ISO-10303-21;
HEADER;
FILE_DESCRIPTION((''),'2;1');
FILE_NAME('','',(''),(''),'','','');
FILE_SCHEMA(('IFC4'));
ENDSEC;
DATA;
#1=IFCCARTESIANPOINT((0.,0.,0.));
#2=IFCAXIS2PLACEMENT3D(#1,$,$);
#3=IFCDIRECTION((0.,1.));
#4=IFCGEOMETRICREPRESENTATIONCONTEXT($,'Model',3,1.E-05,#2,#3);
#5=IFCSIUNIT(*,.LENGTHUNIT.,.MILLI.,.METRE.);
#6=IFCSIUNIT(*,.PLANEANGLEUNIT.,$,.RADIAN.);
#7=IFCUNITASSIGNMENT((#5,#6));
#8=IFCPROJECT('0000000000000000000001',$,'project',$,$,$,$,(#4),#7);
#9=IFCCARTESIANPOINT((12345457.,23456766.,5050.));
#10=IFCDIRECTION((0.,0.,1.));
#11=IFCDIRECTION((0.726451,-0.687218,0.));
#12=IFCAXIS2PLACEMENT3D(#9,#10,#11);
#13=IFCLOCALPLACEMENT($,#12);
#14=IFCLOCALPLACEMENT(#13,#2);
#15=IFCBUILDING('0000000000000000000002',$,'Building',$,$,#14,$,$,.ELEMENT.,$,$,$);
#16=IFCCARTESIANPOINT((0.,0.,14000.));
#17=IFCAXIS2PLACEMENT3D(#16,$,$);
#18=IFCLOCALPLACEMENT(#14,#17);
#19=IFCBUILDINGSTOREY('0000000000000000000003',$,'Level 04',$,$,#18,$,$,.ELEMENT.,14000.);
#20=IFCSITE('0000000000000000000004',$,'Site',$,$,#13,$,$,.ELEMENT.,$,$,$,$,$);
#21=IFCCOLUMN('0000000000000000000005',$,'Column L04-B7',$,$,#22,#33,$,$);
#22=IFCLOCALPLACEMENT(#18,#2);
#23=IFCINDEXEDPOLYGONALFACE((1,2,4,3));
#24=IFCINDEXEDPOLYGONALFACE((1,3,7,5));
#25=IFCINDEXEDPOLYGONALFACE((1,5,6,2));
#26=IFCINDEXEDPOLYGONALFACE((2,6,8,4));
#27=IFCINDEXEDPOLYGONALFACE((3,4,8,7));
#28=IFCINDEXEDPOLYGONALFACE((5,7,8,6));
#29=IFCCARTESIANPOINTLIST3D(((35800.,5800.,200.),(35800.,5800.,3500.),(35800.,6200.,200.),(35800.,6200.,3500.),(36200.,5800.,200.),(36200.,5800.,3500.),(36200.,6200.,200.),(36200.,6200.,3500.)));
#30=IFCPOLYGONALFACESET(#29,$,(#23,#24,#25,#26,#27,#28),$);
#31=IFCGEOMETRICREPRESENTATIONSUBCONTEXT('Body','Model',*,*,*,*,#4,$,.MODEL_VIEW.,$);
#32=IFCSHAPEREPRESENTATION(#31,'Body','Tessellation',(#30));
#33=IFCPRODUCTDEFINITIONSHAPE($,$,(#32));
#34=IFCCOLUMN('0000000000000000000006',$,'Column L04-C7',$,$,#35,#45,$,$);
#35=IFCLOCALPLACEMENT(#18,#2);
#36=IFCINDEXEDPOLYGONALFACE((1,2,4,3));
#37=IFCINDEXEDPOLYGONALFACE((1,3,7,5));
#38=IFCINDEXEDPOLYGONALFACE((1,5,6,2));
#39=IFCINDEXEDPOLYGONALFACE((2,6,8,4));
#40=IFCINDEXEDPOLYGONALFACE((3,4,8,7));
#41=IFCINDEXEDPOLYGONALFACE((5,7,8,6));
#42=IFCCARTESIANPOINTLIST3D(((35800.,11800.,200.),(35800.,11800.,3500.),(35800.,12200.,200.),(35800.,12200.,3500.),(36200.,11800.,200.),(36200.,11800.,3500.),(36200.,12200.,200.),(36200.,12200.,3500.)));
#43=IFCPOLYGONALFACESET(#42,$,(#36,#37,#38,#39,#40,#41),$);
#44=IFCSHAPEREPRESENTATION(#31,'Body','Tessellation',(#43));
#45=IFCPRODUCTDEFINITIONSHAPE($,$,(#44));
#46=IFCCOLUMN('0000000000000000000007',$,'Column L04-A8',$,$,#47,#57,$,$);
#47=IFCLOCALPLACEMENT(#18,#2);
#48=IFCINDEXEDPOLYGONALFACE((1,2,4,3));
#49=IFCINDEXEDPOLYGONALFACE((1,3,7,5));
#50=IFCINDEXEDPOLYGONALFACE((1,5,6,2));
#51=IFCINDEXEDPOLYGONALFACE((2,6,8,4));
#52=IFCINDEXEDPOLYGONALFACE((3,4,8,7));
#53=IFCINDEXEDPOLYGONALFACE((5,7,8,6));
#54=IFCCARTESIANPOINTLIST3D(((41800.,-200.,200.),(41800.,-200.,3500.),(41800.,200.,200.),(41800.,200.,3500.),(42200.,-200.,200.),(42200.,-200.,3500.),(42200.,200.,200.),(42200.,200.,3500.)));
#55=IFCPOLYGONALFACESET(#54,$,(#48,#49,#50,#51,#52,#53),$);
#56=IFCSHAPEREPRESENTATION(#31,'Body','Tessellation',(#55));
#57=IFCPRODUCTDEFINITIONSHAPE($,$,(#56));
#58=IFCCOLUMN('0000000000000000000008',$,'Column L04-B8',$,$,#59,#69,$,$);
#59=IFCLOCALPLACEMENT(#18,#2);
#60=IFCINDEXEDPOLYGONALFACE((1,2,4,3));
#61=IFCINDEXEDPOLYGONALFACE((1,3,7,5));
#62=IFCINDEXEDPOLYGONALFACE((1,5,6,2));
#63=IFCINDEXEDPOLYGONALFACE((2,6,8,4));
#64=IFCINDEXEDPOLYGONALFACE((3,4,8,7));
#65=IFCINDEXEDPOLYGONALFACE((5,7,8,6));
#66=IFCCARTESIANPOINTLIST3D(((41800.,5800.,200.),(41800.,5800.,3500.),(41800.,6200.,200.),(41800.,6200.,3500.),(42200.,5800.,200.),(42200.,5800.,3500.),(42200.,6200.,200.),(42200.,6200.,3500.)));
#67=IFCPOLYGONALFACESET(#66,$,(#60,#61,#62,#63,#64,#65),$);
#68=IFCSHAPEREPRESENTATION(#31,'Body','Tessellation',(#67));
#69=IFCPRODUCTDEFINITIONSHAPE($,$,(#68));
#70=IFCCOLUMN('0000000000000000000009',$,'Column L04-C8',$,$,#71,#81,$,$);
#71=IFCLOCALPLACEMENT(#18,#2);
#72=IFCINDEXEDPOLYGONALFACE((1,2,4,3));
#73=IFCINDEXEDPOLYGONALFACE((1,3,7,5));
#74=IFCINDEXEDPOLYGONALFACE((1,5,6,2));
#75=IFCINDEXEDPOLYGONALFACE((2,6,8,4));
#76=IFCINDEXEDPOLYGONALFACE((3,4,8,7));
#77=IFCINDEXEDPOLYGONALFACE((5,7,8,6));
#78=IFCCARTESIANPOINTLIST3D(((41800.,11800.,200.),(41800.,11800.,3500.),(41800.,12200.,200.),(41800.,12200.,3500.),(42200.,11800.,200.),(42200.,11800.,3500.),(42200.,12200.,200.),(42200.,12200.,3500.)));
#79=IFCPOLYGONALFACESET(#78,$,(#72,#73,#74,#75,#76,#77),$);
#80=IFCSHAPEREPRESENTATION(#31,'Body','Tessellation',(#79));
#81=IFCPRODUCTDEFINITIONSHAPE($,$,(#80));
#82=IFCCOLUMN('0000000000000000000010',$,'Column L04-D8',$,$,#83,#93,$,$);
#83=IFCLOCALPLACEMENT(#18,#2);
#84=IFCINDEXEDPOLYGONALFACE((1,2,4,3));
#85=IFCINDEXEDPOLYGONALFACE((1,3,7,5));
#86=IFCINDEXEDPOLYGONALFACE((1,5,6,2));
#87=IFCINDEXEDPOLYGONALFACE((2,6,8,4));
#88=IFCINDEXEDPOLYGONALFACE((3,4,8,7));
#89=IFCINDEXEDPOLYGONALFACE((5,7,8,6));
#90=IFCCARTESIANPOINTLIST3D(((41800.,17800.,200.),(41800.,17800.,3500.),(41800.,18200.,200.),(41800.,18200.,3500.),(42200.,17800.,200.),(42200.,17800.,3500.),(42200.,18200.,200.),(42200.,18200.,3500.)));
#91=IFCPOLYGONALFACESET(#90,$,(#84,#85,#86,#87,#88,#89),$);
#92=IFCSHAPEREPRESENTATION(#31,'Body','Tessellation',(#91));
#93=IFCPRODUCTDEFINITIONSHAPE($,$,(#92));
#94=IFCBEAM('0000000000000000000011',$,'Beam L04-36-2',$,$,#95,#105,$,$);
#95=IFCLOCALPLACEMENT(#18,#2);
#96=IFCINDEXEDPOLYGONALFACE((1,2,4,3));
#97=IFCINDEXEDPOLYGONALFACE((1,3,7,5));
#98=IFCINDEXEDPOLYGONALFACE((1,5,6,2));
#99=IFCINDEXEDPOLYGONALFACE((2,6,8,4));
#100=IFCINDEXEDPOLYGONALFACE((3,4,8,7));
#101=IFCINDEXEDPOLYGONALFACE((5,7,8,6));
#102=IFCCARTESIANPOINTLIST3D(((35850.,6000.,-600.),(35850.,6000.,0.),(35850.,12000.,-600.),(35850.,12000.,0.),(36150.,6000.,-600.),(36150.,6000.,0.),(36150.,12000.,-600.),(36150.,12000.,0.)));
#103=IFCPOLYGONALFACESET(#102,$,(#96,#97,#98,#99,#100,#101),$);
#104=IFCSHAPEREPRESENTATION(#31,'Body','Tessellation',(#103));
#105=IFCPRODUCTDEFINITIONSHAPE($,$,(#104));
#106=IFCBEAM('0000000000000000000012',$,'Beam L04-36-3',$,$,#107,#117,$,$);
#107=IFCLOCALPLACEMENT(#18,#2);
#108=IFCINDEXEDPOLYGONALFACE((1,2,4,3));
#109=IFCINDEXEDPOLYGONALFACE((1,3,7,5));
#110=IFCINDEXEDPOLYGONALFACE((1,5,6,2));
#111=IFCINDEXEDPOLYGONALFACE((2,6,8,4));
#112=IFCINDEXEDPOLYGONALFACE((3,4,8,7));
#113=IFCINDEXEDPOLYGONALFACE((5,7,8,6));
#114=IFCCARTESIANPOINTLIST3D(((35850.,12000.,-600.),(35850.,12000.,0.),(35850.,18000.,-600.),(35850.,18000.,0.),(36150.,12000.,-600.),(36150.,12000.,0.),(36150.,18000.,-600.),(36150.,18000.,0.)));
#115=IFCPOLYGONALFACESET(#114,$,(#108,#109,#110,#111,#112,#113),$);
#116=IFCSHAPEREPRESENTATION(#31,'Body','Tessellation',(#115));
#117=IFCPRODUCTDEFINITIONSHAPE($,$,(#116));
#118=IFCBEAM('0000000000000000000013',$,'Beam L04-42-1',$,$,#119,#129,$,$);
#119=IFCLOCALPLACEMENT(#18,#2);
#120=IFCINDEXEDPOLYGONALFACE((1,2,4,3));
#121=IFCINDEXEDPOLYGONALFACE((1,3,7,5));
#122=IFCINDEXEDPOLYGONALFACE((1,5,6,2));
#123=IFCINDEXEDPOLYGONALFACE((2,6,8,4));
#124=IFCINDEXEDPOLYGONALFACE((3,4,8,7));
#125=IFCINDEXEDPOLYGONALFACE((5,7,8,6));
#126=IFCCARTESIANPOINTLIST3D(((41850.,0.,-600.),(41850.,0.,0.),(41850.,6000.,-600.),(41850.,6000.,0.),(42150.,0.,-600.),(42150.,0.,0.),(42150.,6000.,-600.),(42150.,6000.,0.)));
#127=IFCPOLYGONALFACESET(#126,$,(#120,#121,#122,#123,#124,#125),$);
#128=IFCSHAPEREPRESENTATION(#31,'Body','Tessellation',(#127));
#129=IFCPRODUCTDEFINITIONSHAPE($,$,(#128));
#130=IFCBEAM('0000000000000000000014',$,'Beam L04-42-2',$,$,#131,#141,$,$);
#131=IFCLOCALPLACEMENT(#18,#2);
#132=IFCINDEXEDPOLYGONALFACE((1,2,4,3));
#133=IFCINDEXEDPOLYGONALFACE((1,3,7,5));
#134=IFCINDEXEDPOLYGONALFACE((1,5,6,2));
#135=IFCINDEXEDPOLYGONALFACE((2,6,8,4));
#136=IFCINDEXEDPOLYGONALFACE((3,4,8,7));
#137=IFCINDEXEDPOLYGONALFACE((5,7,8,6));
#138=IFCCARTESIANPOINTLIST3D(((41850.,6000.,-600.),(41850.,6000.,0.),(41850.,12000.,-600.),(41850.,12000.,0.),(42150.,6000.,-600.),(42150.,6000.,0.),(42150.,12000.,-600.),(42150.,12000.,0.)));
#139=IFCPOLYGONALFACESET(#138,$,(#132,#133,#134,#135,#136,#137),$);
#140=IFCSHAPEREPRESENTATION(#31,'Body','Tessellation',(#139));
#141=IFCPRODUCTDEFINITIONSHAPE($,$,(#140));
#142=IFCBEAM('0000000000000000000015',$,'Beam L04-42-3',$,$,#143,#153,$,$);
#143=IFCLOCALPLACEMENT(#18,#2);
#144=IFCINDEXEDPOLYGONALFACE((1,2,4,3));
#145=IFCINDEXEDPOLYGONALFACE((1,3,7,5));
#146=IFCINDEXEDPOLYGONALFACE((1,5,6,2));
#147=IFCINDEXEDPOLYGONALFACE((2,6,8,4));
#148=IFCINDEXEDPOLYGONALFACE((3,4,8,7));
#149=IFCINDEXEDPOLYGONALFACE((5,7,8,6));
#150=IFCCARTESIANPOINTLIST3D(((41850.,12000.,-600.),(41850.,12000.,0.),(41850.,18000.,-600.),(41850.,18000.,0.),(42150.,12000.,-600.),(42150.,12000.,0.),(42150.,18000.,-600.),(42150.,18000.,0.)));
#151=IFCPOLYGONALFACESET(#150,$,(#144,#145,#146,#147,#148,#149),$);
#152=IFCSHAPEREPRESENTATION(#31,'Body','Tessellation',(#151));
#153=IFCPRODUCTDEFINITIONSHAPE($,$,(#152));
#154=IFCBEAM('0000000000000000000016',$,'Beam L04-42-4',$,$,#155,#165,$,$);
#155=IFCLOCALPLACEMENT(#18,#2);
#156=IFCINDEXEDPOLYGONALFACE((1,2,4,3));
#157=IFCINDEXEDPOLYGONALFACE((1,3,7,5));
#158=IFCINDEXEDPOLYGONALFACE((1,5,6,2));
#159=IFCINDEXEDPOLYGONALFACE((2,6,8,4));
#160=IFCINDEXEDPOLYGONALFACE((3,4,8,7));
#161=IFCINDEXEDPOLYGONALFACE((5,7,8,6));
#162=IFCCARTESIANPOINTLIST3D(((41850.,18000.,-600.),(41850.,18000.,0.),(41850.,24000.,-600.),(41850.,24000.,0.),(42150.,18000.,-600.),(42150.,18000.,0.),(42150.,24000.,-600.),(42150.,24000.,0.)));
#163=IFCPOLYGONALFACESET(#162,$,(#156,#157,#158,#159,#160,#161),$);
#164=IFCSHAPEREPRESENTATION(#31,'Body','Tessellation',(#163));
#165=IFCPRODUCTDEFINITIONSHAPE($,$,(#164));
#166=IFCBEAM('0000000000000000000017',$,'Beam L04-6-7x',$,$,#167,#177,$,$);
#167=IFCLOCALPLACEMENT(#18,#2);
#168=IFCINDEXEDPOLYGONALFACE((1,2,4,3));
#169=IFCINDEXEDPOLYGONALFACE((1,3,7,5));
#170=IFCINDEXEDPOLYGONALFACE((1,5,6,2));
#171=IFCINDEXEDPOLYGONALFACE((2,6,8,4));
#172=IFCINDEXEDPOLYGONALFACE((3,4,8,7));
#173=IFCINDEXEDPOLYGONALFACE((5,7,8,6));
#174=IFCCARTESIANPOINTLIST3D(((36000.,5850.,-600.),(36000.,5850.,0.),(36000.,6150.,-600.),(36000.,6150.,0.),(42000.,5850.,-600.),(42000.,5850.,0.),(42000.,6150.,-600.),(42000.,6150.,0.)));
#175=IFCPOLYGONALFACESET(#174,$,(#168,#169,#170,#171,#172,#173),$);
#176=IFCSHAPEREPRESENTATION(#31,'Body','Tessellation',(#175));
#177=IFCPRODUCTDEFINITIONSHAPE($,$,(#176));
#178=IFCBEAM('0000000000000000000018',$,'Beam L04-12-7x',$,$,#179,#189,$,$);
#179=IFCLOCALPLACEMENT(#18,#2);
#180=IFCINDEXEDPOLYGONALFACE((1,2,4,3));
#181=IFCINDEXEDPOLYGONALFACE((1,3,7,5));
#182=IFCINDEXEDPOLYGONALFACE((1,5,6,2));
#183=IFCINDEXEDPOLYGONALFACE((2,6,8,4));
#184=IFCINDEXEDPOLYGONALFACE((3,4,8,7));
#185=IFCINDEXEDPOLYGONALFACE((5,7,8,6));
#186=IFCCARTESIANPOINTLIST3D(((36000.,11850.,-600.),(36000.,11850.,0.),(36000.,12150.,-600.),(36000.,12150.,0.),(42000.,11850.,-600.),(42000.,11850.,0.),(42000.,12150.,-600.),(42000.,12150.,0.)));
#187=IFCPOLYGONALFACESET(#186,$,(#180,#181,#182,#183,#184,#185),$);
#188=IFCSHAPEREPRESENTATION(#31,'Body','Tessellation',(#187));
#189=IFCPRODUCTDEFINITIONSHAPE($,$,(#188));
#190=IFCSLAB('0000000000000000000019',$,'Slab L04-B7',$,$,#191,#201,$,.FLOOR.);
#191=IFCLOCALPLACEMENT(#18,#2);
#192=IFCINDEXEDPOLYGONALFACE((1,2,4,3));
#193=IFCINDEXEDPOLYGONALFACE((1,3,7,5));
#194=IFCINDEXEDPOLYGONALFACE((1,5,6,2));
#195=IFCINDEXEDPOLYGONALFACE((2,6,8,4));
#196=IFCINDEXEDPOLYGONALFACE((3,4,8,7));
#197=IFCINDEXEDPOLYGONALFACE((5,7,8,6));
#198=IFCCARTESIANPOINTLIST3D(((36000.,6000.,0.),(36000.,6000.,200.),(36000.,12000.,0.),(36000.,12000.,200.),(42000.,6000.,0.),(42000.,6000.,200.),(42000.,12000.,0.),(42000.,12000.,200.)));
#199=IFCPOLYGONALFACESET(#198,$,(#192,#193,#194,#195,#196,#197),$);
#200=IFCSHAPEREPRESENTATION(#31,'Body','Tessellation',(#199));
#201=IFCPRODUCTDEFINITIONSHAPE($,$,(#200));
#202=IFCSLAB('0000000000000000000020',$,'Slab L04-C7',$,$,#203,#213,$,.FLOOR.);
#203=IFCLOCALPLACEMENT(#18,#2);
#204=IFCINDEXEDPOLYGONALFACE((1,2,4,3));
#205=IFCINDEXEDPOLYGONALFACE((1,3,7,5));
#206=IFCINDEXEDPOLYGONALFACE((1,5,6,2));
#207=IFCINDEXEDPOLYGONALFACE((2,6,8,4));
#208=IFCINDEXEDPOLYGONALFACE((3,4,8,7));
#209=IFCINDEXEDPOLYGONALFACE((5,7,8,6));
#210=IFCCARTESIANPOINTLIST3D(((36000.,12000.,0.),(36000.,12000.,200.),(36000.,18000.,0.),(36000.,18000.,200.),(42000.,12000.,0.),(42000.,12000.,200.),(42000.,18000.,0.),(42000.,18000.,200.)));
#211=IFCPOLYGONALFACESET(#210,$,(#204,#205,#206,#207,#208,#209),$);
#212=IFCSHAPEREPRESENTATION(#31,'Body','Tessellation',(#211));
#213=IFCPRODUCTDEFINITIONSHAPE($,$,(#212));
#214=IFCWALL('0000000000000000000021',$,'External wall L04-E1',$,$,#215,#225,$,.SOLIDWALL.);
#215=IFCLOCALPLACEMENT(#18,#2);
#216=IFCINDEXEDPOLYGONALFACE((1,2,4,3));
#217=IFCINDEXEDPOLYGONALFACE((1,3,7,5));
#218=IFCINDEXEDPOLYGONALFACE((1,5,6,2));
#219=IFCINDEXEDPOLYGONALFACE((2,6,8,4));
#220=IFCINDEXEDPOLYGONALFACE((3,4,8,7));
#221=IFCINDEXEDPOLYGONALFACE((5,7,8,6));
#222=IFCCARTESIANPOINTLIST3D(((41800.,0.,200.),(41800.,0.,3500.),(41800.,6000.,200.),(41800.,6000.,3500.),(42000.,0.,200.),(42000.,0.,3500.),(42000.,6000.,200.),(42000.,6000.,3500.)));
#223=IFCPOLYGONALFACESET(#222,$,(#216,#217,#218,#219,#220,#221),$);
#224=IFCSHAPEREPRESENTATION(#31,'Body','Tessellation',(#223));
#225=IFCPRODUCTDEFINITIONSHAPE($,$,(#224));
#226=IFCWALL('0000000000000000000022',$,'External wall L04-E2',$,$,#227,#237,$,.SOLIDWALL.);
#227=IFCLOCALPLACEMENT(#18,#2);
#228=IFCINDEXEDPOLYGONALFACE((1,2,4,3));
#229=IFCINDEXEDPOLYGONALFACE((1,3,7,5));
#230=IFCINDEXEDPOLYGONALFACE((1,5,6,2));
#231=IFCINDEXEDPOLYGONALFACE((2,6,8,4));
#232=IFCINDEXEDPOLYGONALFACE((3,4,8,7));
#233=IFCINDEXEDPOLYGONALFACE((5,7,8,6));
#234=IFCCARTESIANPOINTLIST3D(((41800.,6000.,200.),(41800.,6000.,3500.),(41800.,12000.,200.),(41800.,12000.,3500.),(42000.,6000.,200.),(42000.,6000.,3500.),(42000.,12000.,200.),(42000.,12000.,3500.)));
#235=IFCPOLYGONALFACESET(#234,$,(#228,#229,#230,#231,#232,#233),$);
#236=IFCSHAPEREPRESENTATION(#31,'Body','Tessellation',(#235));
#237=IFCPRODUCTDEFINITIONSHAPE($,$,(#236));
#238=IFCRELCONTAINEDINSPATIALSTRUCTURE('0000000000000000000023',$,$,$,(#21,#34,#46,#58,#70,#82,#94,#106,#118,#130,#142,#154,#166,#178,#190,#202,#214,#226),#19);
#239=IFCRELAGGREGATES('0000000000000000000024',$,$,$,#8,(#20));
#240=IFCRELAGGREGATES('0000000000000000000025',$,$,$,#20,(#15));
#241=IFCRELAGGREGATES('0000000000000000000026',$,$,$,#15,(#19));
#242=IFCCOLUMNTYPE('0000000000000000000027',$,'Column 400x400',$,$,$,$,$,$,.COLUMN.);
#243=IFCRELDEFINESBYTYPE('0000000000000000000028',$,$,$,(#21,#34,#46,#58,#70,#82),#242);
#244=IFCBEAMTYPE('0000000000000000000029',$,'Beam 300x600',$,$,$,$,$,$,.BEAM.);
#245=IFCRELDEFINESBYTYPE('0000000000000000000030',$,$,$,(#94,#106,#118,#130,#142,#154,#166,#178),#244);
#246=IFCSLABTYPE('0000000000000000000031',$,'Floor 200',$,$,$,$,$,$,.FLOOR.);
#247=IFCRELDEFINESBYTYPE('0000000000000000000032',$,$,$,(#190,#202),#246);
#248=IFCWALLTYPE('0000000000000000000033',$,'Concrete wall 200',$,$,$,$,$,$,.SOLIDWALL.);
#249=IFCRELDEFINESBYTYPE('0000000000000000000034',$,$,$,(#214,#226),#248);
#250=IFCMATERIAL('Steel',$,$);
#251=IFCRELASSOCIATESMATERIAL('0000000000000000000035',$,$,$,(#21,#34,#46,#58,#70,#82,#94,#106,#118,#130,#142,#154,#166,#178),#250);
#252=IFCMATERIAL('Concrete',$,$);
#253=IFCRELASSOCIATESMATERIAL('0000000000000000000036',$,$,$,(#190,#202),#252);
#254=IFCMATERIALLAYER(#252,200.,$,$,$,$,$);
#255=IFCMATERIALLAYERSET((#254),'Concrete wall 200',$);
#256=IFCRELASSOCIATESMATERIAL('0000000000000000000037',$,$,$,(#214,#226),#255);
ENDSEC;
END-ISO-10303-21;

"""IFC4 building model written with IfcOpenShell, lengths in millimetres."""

from ifc_helpers import new_model, si_unit, direction, frame, origin, place, context, subcontext, project, spatial, rectangle, extrude, material, layer, layer_set, layer_usage, type_object, element, save


model = new_model("IFC4")

# Units and contexts
model_context = context("Model", 3, precision=1e-05, world=origin(), true_north=direction((0.0, 1.0)))
body_context = subcontext(model_context, "Body", "Model", "MODEL_VIEW")
ifc_project = project(units=[si_unit("LENGTHUNIT", "METRE", prefix="MILLI"), si_unit("PLANEANGLEUNIT", "RADIAN")], contexts=[model_context])

# Site, building, storey
site_placement = place(None, frame((12345457.0, 23456766.0, 5050.0), z_axis=(0.0, 0.0, 1.0), x_axis=(0.726451, -0.687218, 0.0)))
site = spatial("IfcSite", under=ifc_project, at=site_placement, Name="Site", CompositionType="ELEMENT")
building_placement = place(site_placement, origin())
building = spatial("IfcBuilding", under=site, at=building_placement, Name="Building", CompositionType="ELEMENT")
storey_placement = place(building_placement, frame((0.0, 0.0, 14000.0)))
storey = spatial("IfcBuildingStorey", under=building, at=storey_placement, Name="Level 04", CompositionType="ELEMENT", Elevation=14000.0)

# Columns
ifc_material_1 = material(Name="Steel")
column_type = type_object("IfcColumnType", Name="Column 400x400", PredefinedType="COLUMN")
for number, where, name in (
    (1, (35800.0, 5800.0, 200.0), "Column L04-B7"),
    (2, (35800.0, 11800.0, 200.0), "Column L04-C7"),
    (3, (41800.0, -200.0, 200.0), "Column L04-A8"),
    (4, (41800.0, 5800.0, 200.0), "Column L04-B8"),
    (5, (41800.0, 11800.0, 200.0), "Column L04-C8"),
    (6, (41800.0, 17800.0, 200.0), "Column L04-D8"),
):
    element("IfcColumn", number, at=place(storey_placement, frame(where)), inside=storey, type_object=column_type, material=ifc_material_1, Name=name, context=body_context, shape_type="SweptSolid", body=[
        extrude(rectangle(XDim=400.0, YDim=400.0), frame((200.0, 200.0, 0.0)), (0.0, 0.0, 1.0), 3300.0),
    ])

# Beams
beam_type = type_object("IfcBeamType", Name="Beam 300x600", PredefinedType="BEAM")
for number, where, name in (
    (7, (35850.0, 6000.0, -600.0), "Beam L04-36-2"),
    (8, (35850.0, 12000.0, -600.0), "Beam L04-36-3"),
    (9, (41850.0, 0.0, -600.0), "Beam L04-42-1"),
    (10, (41850.0, 6000.0, -600.0), "Beam L04-42-2"),
    (11, (41850.0, 12000.0, -600.0), "Beam L04-42-3"),
    (12, (41850.0, 18000.0, -600.0), "Beam L04-42-4"),
):
    element("IfcBeam", number, at=place(storey_placement, frame(where)), inside=storey, type_object=beam_type, material=ifc_material_1, Name=name, context=body_context, shape_type="SweptSolid", body=[
        extrude(rectangle(XDim=300.0, YDim=6000.0), frame((150.0, 3000.0, 0.0)), (0.0, 0.0, 1.0), 600.0),
    ])
for number, where, name in (
    (13, (36000.0, 5850.0, -600.0), "Beam L04-6-7x"),
    (14, (36000.0, 11850.0, -600.0), "Beam L04-12-7x"),
):
    element("IfcBeam", number, at=place(storey_placement, frame(where)), inside=storey, type_object=beam_type, material=ifc_material_1, Name=name, context=body_context, shape_type="SweptSolid", body=[
        extrude(rectangle(XDim=6000.0, YDim=300.0), frame((3000.0, 150.0, 0.0)), (0.0, 0.0, 1.0), 600.0),
    ])

# Slabs
ifc_material_2 = material(Name="Concrete")
slab_type = type_object("IfcSlabType", Name="Floor 200", PredefinedType="FLOOR")
for number, where, name in (
    (15, (36000.0, 6000.0, 0.0), "Slab L04-B7"),
    (16, (36000.0, 12000.0, 0.0), "Slab L04-C7"),
):
    element("IfcSlab", number, at=place(storey_placement, frame(where)), inside=storey, type_object=slab_type, material=ifc_material_2, Name=name, PredefinedType="FLOOR", context=body_context, shape_type="SweptSolid", body=[
        extrude(rectangle(XDim=6000.0, YDim=6000.0), frame((3000.0, 3000.0, 0.0)), (0.0, 0.0, 1.0), 200.0),
    ])

# Walls
ifc_layer_1 = layer(ifc_material_2, 200.0)
ifc_layer_set_1 = layer_set([ifc_layer_1], Name="Concrete wall 200")
ifc_layer_usage_1 = layer_usage(ifc_layer_set_1, "AXIS2", "POSITIVE", 0.0)
wall_type_1 = type_object("IfcWallType", Name="Concrete wall 200", PredefinedType="SOLIDWALL")
for number, where, name in (
    (17, (41800.0, 0.0, 200.0), "External wall L04-E1"),
    (18, (41800.0, 6000.0, 200.0), "External wall L04-E2"),
):
    element("IfcWall", number, at=place(storey_placement, frame(where)), inside=storey, type_object=wall_type_1, material=ifc_layer_usage_1, Name=name, PredefinedType="SOLIDWALL", context=body_context, shape_type="SweptSolid", body=[
        extrude(rectangle(XDim=200.0, YDim=6000.0), frame((100.0, 3000.0, 0.0)), (0.0, 0.0, 1.0), 3300.0),
    ])

save(model, "model.ifc")
